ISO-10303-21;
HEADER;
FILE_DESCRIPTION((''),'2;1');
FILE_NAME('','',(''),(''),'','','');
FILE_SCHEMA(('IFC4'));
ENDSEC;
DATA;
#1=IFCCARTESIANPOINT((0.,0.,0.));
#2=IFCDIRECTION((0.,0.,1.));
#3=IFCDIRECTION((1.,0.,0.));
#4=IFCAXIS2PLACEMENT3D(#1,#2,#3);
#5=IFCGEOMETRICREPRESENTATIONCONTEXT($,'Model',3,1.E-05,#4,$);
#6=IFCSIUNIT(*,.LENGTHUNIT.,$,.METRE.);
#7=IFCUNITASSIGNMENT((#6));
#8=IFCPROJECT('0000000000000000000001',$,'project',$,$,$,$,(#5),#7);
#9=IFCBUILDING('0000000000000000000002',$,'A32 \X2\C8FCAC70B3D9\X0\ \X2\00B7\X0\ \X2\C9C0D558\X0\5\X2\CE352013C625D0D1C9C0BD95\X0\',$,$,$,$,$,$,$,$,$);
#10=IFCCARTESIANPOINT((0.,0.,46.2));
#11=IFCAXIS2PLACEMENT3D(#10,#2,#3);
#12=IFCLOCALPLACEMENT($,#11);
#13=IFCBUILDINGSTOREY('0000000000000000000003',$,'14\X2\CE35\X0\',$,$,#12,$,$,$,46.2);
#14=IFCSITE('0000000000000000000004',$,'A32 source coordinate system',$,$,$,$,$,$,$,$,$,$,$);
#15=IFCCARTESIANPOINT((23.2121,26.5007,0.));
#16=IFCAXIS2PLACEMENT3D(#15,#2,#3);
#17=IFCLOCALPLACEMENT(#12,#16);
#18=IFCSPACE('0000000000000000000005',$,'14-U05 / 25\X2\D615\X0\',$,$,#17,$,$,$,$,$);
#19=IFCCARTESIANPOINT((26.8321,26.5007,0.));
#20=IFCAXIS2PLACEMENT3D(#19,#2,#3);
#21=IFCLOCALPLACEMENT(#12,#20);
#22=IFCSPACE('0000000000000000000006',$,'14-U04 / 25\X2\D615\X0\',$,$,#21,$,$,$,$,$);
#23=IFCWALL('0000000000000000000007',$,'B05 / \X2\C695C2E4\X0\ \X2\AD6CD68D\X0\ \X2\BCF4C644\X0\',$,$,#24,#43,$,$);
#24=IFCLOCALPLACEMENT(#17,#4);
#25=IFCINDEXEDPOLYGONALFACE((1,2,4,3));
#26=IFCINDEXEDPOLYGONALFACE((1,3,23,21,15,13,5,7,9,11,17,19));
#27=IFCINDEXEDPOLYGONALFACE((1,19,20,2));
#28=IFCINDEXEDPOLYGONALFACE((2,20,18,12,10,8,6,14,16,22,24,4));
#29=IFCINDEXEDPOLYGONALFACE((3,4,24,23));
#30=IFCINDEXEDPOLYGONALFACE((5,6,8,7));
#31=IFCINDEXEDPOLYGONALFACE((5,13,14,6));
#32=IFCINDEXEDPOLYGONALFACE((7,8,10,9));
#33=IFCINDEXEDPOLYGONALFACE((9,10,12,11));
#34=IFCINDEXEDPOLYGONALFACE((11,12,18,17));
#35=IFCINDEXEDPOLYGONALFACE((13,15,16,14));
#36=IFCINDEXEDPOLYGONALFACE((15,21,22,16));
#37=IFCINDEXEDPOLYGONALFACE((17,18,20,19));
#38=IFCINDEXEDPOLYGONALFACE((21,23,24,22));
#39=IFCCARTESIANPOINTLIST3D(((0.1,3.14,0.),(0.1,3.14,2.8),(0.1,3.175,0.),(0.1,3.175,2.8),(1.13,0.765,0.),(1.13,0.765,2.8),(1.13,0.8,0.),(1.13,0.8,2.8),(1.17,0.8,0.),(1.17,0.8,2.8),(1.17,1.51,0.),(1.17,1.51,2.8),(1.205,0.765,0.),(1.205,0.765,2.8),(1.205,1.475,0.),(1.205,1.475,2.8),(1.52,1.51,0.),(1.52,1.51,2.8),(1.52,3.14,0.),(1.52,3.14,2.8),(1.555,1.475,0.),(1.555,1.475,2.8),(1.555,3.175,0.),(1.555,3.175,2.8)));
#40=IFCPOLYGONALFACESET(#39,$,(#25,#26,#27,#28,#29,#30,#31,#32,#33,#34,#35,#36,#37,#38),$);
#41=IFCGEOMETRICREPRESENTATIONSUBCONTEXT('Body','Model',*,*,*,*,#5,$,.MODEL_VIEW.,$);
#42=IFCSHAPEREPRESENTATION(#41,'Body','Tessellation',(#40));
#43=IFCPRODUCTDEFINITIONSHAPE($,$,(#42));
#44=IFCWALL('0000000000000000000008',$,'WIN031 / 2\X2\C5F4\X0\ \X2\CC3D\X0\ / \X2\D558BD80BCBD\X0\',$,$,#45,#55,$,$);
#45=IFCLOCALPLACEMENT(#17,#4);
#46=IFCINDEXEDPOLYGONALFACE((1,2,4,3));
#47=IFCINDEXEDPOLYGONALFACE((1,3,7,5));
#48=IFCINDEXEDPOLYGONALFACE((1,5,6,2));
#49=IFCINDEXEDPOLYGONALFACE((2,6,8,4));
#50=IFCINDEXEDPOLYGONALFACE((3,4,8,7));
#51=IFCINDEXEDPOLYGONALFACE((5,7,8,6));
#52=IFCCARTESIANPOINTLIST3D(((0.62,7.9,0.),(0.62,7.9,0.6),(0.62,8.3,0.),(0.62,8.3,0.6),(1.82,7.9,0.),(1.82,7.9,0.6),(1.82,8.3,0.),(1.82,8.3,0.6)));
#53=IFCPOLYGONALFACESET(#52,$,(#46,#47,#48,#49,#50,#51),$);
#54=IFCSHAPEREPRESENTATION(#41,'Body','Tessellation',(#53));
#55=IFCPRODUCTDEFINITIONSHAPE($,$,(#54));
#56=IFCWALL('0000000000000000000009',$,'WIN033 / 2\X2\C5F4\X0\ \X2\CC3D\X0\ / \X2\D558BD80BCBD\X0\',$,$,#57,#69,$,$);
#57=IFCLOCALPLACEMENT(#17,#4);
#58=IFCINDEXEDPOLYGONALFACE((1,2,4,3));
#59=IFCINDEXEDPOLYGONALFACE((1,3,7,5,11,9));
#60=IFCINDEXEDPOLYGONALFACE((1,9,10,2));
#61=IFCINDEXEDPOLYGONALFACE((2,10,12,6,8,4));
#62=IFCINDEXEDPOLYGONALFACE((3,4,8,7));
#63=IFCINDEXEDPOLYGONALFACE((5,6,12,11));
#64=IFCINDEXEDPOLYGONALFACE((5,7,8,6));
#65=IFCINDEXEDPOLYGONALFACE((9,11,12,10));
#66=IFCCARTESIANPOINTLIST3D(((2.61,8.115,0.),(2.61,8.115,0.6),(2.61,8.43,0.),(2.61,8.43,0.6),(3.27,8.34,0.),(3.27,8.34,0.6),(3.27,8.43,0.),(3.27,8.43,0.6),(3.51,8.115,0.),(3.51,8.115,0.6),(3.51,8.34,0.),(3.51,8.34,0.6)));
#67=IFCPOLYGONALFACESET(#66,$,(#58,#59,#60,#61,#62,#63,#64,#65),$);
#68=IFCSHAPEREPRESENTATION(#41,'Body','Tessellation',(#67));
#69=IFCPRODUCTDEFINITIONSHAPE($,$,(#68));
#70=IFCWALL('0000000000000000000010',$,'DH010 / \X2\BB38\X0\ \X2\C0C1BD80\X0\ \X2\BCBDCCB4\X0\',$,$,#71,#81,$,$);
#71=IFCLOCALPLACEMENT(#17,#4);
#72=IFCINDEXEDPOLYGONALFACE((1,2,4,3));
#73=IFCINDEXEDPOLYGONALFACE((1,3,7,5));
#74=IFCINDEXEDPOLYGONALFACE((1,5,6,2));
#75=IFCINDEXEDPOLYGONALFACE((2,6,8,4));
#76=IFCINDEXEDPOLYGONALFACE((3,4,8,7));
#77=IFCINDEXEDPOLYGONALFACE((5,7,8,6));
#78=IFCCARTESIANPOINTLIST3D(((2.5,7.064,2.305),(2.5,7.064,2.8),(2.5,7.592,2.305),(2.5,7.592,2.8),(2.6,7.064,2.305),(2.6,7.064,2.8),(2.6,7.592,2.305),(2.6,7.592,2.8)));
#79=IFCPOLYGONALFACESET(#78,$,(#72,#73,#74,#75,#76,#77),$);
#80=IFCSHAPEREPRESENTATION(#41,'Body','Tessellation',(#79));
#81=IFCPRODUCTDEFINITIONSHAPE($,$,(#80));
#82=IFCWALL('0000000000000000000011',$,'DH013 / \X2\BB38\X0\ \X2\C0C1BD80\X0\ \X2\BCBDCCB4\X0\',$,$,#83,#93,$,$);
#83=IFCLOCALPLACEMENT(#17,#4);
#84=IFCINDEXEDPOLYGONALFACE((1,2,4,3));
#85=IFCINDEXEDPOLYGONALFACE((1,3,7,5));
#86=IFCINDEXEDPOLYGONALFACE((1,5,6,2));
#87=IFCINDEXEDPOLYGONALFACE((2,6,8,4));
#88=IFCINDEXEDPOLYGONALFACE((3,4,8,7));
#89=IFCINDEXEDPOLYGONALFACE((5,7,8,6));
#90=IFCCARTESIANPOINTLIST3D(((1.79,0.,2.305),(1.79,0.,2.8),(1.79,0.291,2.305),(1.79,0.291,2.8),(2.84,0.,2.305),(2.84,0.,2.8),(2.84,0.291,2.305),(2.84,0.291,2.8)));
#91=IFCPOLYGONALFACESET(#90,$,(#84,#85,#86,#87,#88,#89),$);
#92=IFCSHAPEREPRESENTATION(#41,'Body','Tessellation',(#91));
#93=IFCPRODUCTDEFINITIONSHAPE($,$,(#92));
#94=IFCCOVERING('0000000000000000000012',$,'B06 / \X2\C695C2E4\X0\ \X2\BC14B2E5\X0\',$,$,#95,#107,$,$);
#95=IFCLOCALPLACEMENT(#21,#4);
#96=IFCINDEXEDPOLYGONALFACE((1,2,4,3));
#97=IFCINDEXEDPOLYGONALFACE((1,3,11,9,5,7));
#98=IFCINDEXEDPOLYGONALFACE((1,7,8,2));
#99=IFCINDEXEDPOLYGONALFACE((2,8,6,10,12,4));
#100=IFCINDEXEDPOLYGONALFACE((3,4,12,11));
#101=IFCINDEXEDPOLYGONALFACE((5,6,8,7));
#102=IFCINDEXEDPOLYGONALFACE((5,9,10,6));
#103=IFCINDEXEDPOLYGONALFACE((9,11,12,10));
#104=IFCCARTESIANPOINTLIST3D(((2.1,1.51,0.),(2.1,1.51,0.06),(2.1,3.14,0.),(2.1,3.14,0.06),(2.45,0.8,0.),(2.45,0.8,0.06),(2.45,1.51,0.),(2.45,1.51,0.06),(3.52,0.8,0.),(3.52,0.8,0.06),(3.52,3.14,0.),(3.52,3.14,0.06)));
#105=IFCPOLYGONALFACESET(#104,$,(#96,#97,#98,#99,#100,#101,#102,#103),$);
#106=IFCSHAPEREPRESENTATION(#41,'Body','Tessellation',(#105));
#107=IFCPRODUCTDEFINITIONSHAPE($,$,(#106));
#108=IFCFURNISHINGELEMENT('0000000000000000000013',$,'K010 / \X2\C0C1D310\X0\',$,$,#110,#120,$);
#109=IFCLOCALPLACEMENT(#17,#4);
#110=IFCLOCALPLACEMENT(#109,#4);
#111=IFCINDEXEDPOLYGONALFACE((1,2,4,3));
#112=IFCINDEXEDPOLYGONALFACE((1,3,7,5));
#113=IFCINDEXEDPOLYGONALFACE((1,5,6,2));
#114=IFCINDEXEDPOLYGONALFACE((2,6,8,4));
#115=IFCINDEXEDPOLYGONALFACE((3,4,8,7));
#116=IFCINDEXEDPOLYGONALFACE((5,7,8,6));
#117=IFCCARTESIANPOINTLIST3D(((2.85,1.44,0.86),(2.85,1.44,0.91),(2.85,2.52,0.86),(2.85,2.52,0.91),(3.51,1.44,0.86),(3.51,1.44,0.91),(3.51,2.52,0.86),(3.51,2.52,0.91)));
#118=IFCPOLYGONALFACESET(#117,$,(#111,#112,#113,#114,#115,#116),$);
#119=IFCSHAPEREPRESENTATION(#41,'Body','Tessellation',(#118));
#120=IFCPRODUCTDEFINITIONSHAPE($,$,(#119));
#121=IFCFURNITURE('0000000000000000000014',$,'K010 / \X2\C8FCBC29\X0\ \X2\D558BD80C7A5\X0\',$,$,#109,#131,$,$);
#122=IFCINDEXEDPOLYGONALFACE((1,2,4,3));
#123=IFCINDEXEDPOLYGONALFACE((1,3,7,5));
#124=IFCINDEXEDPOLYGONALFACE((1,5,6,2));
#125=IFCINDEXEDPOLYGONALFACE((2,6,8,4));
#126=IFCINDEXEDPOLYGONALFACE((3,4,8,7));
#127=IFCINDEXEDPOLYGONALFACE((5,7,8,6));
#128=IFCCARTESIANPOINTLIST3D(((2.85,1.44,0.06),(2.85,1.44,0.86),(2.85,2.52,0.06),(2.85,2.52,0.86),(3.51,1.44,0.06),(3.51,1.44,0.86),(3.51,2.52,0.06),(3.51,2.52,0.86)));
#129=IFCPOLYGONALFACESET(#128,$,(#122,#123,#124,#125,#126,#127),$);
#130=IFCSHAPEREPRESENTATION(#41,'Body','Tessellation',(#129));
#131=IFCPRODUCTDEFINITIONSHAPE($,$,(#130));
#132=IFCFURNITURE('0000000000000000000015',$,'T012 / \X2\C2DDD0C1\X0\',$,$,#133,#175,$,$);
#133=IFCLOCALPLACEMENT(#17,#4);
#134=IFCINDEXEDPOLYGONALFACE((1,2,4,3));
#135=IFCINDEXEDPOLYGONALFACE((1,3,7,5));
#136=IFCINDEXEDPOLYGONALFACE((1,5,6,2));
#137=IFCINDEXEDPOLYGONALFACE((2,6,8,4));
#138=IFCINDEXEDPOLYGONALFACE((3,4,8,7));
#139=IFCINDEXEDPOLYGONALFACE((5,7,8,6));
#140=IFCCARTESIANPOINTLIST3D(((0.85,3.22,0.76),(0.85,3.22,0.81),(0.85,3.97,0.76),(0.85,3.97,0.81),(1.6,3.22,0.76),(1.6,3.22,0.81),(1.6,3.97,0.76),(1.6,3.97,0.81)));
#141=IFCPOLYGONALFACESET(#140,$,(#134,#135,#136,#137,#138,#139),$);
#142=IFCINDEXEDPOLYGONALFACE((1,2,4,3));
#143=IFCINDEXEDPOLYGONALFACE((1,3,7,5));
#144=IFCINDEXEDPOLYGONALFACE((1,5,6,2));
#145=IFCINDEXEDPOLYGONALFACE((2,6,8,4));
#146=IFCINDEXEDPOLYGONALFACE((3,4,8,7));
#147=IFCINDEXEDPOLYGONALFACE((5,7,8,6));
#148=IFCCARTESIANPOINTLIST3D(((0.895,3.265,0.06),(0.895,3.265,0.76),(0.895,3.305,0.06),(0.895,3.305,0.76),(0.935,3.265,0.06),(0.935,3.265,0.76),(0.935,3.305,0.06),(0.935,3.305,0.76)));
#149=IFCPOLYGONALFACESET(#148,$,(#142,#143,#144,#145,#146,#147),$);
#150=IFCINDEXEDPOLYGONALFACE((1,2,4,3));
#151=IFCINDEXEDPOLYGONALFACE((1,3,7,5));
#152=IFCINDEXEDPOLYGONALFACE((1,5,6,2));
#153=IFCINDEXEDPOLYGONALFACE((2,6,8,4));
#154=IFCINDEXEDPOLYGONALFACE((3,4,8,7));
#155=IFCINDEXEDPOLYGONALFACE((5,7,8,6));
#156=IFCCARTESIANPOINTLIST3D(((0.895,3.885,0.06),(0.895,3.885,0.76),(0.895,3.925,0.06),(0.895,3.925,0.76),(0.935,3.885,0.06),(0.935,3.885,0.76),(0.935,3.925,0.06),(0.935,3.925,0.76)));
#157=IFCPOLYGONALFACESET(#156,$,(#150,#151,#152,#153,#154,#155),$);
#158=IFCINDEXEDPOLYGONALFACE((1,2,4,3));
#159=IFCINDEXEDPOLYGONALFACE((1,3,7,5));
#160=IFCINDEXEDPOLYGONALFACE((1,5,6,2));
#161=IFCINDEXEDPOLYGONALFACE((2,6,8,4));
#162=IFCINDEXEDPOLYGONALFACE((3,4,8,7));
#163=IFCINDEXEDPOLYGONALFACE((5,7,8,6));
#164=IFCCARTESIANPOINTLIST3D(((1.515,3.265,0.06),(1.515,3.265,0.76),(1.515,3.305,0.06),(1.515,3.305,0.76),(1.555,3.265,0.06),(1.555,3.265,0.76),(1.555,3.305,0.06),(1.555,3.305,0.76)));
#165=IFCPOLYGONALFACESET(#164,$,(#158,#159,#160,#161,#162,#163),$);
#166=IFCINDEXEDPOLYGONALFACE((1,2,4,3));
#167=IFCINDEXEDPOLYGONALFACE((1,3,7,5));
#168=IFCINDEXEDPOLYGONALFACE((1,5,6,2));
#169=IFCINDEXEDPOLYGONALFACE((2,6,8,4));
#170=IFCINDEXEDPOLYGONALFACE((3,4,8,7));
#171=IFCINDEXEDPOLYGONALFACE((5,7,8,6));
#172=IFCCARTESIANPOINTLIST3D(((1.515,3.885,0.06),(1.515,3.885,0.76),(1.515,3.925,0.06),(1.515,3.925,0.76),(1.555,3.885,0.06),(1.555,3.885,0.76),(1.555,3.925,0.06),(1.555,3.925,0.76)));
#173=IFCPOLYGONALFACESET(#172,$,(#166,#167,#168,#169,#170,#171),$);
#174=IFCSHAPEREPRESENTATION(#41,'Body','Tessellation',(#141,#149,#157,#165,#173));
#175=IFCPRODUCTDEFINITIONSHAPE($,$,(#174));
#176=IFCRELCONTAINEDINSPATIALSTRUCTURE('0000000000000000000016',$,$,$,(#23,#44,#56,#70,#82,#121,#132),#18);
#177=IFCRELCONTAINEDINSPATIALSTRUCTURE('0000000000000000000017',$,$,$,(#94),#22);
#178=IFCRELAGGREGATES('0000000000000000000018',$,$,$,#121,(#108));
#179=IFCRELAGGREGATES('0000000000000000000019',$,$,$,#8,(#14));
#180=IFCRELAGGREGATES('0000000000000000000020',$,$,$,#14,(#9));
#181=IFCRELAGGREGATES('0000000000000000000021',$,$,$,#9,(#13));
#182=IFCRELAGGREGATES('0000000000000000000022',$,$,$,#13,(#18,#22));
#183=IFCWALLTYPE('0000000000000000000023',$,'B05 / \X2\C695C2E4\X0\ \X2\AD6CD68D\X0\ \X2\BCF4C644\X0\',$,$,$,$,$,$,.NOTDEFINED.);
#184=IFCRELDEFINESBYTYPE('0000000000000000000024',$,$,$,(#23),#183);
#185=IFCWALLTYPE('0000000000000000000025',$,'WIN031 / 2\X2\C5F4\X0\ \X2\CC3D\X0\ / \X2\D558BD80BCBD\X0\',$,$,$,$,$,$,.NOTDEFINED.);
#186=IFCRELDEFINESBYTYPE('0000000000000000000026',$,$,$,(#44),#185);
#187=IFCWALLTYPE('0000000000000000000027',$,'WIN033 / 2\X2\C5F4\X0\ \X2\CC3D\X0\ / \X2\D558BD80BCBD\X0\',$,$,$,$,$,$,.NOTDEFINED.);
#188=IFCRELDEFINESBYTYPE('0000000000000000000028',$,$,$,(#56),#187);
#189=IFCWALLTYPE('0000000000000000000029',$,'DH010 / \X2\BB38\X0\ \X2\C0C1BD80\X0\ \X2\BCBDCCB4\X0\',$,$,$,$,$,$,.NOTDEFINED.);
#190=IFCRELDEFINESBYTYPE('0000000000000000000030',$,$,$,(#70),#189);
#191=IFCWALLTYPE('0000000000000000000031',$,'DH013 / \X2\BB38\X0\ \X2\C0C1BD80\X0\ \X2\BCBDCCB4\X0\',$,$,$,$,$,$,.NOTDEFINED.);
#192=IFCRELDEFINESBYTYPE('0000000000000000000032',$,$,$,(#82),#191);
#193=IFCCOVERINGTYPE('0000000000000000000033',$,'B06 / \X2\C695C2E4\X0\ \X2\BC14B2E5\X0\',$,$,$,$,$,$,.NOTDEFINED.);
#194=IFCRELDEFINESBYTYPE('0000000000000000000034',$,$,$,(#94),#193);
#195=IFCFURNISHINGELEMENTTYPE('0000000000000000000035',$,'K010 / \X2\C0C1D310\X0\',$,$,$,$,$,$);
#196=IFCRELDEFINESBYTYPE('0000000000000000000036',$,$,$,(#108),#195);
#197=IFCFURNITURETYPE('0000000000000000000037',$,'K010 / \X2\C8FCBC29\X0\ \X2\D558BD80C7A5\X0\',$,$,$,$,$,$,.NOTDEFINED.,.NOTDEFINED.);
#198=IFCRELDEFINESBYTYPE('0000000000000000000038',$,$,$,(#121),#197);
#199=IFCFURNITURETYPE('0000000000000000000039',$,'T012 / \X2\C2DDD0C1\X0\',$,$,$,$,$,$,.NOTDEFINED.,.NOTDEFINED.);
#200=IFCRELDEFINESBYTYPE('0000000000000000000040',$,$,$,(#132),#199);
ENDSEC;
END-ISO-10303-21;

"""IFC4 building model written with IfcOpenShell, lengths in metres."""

from ifc_helpers import new_model, si_unit, frame, origin, origin_with_axes, place, context, subcontext, project, spatial, polyline, outline, extrude, source, transform, mapped, type_object, type_shapes, element, aggregate, save


model = new_model("IFC4")

# Units and contexts
model_context = context("Model", 3, precision=1e-05, world=origin_with_axes())
body_context = subcontext(model_context, "Body", "Model", "MODEL_VIEW")
ifc_project = project(units=[si_unit("LENGTHUNIT", "METRE")], contexts=[model_context])

# Site, building, storey, space
site = spatial("IfcSite", under=ifc_project, Name="A32 source coordinate system")
building = spatial("IfcBuilding", under=site, Name="A32 주거동 · 지하5층–옥탑지붕")
storey_placement = place(None, frame((0.0, 0.0, 46.2), z_axis=(0.0, 0.0, 1.0), x_axis=(1.0, 0.0, 0.0)))
storey = spatial("IfcBuildingStorey", under=building, at=storey_placement, Name="14층", Elevation=46.2)
space_1_placement = place(storey_placement, frame((23.2121, 26.5007, 0.0), z_axis=(0.0, 0.0, 1.0), x_axis=(1.0, 0.0, 0.0)))
space_1 = spatial("IfcSpace", under=storey, at=space_1_placement, Name="14-U05 / 25형")

# Walls
wall_type_1 = type_object("IfcWallType", Name="B05 / 욕실 구획 보완", PredefinedType="NOTDEFINED")
shared_shape_1 = source(origin(), body_context, "Body", "SweptSolid", [
    extrude(outline(polyline([(1.17, 1.51), (1.52, 1.51), (1.52, 3.14), (0.1, 3.14), (0.1, 3.175), (1.555, 3.175), (1.555, 1.475), (1.205, 1.475), (1.205, 0.765), (1.13, 0.765), (1.13, 0.8), (1.17, 0.8), (1.17, 1.51)])), origin(), (0.0, 0.0, 1.0), 2.8),
])
type_shapes(wall_type_1, [shared_shape_1])
wall_1_placement = place(space_1_placement, origin_with_axes())
element("IfcWall", 1, at=wall_1_placement, inside=space_1, type_object=wall_type_1, Name="B05 / 욕실 구획 보완", context=body_context, shape_type="MappedRepresentation", body=[
    mapped(shared_shape_1, transform((0.0, 0.0, 0.0), scale=1.0)),
])
wall_type_2 = type_object("IfcWallType", Name="WIN031 / 2열 창 / 하부벽", PredefinedType="NOTDEFINED")
shared_shape_2 = source(origin(), body_context, "Body", "SweptSolid", [
    extrude(outline(polyline([(0.62, 8.3), (1.82, 8.3), (1.82, 7.9), (0.62, 7.9), (0.62, 8.3)])), origin(), (0.0, 0.0, 1.0), 0.6),
])
type_shapes(wall_type_2, [shared_shape_2])
wall_2_placement = place(space_1_placement, origin_with_axes())
element("IfcWall", 2, at=wall_2_placement, inside=space_1, type_object=wall_type_2, Name="WIN031 / 2열 창 / 하부벽", context=body_context, shape_type="MappedRepresentation", body=[
    mapped(shared_shape_2, transform((0.0, 0.0, 0.0), scale=1.0)),
])
wall_type_3 = type_object("IfcWallType", Name="WIN033 / 2열 창 / 하부벽", PredefinedType="NOTDEFINED")
shared_shape_3 = source(origin(), body_context, "Body", "SweptSolid", [
    extrude(outline(polyline([(2.61, 8.43), (3.27, 8.43), (3.27, 8.34), (3.51, 8.34), (3.51, 8.115), (2.61, 8.115), (2.61, 8.43)])), origin(), (0.0, 0.0, 1.0), 0.6),
])
type_shapes(wall_type_3, [shared_shape_3])
wall_3_placement = place(space_1_placement, origin_with_axes())
element("IfcWall", 3, at=wall_3_placement, inside=space_1, type_object=wall_type_3, Name="WIN033 / 2열 창 / 하부벽", context=body_context, shape_type="MappedRepresentation", body=[
    mapped(shared_shape_3, transform((0.0, 0.0, 0.0), scale=1.0)),
])
wall_type_4 = type_object("IfcWallType", Name="DH010 / 문 상부 벽체", PredefinedType="NOTDEFINED")
shared_shape_4 = source(origin(), body_context, "Body", "SweptSolid", [
    extrude(outline(polyline([(2.5, 7.592), (2.6, 7.592), (2.6, 7.064), (2.5, 7.064), (2.5, 7.592)])), frame((0.0, 0.0, 2.305)), (0.0, 0.0, 1.0), 0.495),
])
type_shapes(wall_type_4, [shared_shape_4])
wall_4_placement = place(space_1_placement, origin_with_axes())
element("IfcWall", 4, at=wall_4_placement, inside=space_1, type_object=wall_type_4, Name="DH010 / 문 상부 벽체", context=body_context, shape_type="MappedRepresentation", body=[
    mapped(shared_shape_4, transform((0.0, 0.0, 0.0), scale=1.0)),
])
wall_type_5 = type_object("IfcWallType", Name="DH013 / 문 상부 벽체", PredefinedType="NOTDEFINED")
shared_shape_5 = source(origin(), body_context, "Body", "SweptSolid", [
    extrude(outline(polyline([(2.84, 0.291), (2.84, 0.0), (1.79, 0.0), (1.79, 0.291), (2.84, 0.291)])), frame((0.0, 0.0, 2.305)), (0.0, 0.0, 1.0), 0.495),
])
type_shapes(wall_type_5, [shared_shape_5])
wall_5_placement = place(space_1_placement, origin_with_axes())
element("IfcWall", 5, at=wall_5_placement, inside=space_1, type_object=wall_type_5, Name="DH013 / 문 상부 벽체", context=body_context, shape_type="MappedRepresentation", body=[
    mapped(shared_shape_5, transform((0.0, 0.0, 0.0), scale=1.0)),
])

# Shared definitions
space_2_placement = place(storey_placement, frame((26.8321, 26.5007, 0.0), z_axis=(0.0, 0.0, 1.0), x_axis=(1.0, 0.0, 0.0)))
space_2 = spatial("IfcSpace", under=storey, at=space_2_placement, Name="14-U04 / 25형")

# Covering
covering_type = type_object("IfcCoveringType", Name="B06 / 욕실 바닥", PredefinedType="NOTDEFINED")
shared_shape_6 = source(origin(), body_context, "Body", "SweptSolid", [
    extrude(outline(polyline([(2.1, 3.14), (3.52, 3.14), (3.52, 0.8), (2.45, 0.8), (2.45, 1.51), (2.1, 1.51), (2.1, 3.14)])), origin(), (0.0, 0.0, 1.0), 0.06),
])
type_shapes(covering_type, [shared_shape_6])
covering_placement = place(space_2_placement, origin_with_axes())
element("IfcCovering", 6, at=covering_placement, inside=space_2, type_object=covering_type, Name="B06 / 욕실 바닥", context=body_context, shape_type="MappedRepresentation", body=[
    mapped(shared_shape_6, transform((0.0, 0.0, 0.0), scale=1.0)),
])

# Furnishing element
furnishing_element_type_1 = type_object("IfcFurnishingElementType", Name="K010 / 상판")
shared_shape_7 = source(origin(), body_context, "Body", "SweptSolid", [
    extrude(outline(polyline([(2.85, 2.52), (3.51, 2.52), (3.51, 1.44), (2.85, 1.44), (2.85, 2.52)])), frame((0.0, 0.0, 0.86)), (0.0, 0.0, 1.0), 0.05),
])
type_shapes(furnishing_element_type_1, [shared_shape_7])
furniture_1_placement = place(space_1_placement, origin_with_axes())
furnishing_1_placement = place(furniture_1_placement, origin_with_axes())
furnishing_1 = element("IfcFurnishingElement", 7, at=furnishing_1_placement, type_object=furnishing_element_type_1, Name="K010 / 상판", context=body_context, shape_type="MappedRepresentation", body=[
    mapped(shared_shape_7, transform((0.0, 0.0, 0.0), scale=1.0)),
])

# Furniture
furniture_type_1 = type_object("IfcFurnitureType", Name="K010 / 주방 하부장", AssemblyPlace="NOTDEFINED", PredefinedType="NOTDEFINED")
shared_shape_8 = source(origin(), body_context, "Body", "SweptSolid", [
    extrude(outline(polyline([(2.85, 1.44), (2.85, 2.52), (3.51, 2.52), (3.51, 1.44), (2.85, 1.44)])), frame((0.0, 0.0, 0.06)), (0.0, 0.0, 1.0), 0.8),
])
type_shapes(furniture_type_1, [shared_shape_8])
furniture_1 = element("IfcFurniture", 8, at=furniture_1_placement, inside=space_1, type_object=furniture_type_1, Name="K010 / 주방 하부장", context=body_context, shape_type="MappedRepresentation", body=[
    mapped(shared_shape_8, transform((0.0, 0.0, 0.0), scale=1.0)),
])
aggregate(furniture_1, [furnishing_1])
furniture_type_2 = type_object("IfcFurnitureType", Name="T012 / 식탁", AssemblyPlace="NOTDEFINED", PredefinedType="NOTDEFINED")
shared_shape_9 = source(origin(), body_context, "Body", "SweptSolid", [
    extrude(outline(polyline([(1.6, 3.97), (1.6, 3.22), (0.85, 3.22), (0.85, 3.97), (1.6, 3.97)])), frame((0.0, 0.0, 0.76)), (0.0, 0.0, 1.0), 0.05),
    extrude(outline(polyline([(0.895, 3.265), (0.895, 3.305), (0.935, 3.305), (0.935, 3.265), (0.895, 3.265)])), frame((0.0, 0.0, 0.06)), (0.0, 0.0, 1.0), 0.7),
    extrude(outline(polyline([(0.895, 3.885), (0.895, 3.925), (0.935, 3.925), (0.935, 3.885), (0.895, 3.885)])), frame((0.0, 0.0, 0.06)), (0.0, 0.0, 1.0), 0.7),
    extrude(outline(polyline([(1.515, 3.265), (1.515, 3.305), (1.555, 3.305), (1.555, 3.265), (1.515, 3.265)])), frame((0.0, 0.0, 0.06)), (0.0, 0.0, 1.0), 0.7),
    extrude(outline(polyline([(1.515, 3.885), (1.515, 3.925), (1.555, 3.925), (1.555, 3.885), (1.515, 3.885)])), frame((0.0, 0.0, 0.06)), (0.0, 0.0, 1.0), 0.7),
])
type_shapes(furniture_type_2, [shared_shape_9])
furniture_2_placement = place(space_1_placement, origin_with_axes())
element("IfcFurniture", 9, at=furniture_2_placement, inside=space_1, type_object=furniture_type_2, Name="T012 / 식탁", context=body_context, shape_type="MappedRepresentation", body=[
    mapped(shared_shape_9, transform((0.0, 0.0, 0.0), scale=1.0)),
])

save(model, "model.ifc")
